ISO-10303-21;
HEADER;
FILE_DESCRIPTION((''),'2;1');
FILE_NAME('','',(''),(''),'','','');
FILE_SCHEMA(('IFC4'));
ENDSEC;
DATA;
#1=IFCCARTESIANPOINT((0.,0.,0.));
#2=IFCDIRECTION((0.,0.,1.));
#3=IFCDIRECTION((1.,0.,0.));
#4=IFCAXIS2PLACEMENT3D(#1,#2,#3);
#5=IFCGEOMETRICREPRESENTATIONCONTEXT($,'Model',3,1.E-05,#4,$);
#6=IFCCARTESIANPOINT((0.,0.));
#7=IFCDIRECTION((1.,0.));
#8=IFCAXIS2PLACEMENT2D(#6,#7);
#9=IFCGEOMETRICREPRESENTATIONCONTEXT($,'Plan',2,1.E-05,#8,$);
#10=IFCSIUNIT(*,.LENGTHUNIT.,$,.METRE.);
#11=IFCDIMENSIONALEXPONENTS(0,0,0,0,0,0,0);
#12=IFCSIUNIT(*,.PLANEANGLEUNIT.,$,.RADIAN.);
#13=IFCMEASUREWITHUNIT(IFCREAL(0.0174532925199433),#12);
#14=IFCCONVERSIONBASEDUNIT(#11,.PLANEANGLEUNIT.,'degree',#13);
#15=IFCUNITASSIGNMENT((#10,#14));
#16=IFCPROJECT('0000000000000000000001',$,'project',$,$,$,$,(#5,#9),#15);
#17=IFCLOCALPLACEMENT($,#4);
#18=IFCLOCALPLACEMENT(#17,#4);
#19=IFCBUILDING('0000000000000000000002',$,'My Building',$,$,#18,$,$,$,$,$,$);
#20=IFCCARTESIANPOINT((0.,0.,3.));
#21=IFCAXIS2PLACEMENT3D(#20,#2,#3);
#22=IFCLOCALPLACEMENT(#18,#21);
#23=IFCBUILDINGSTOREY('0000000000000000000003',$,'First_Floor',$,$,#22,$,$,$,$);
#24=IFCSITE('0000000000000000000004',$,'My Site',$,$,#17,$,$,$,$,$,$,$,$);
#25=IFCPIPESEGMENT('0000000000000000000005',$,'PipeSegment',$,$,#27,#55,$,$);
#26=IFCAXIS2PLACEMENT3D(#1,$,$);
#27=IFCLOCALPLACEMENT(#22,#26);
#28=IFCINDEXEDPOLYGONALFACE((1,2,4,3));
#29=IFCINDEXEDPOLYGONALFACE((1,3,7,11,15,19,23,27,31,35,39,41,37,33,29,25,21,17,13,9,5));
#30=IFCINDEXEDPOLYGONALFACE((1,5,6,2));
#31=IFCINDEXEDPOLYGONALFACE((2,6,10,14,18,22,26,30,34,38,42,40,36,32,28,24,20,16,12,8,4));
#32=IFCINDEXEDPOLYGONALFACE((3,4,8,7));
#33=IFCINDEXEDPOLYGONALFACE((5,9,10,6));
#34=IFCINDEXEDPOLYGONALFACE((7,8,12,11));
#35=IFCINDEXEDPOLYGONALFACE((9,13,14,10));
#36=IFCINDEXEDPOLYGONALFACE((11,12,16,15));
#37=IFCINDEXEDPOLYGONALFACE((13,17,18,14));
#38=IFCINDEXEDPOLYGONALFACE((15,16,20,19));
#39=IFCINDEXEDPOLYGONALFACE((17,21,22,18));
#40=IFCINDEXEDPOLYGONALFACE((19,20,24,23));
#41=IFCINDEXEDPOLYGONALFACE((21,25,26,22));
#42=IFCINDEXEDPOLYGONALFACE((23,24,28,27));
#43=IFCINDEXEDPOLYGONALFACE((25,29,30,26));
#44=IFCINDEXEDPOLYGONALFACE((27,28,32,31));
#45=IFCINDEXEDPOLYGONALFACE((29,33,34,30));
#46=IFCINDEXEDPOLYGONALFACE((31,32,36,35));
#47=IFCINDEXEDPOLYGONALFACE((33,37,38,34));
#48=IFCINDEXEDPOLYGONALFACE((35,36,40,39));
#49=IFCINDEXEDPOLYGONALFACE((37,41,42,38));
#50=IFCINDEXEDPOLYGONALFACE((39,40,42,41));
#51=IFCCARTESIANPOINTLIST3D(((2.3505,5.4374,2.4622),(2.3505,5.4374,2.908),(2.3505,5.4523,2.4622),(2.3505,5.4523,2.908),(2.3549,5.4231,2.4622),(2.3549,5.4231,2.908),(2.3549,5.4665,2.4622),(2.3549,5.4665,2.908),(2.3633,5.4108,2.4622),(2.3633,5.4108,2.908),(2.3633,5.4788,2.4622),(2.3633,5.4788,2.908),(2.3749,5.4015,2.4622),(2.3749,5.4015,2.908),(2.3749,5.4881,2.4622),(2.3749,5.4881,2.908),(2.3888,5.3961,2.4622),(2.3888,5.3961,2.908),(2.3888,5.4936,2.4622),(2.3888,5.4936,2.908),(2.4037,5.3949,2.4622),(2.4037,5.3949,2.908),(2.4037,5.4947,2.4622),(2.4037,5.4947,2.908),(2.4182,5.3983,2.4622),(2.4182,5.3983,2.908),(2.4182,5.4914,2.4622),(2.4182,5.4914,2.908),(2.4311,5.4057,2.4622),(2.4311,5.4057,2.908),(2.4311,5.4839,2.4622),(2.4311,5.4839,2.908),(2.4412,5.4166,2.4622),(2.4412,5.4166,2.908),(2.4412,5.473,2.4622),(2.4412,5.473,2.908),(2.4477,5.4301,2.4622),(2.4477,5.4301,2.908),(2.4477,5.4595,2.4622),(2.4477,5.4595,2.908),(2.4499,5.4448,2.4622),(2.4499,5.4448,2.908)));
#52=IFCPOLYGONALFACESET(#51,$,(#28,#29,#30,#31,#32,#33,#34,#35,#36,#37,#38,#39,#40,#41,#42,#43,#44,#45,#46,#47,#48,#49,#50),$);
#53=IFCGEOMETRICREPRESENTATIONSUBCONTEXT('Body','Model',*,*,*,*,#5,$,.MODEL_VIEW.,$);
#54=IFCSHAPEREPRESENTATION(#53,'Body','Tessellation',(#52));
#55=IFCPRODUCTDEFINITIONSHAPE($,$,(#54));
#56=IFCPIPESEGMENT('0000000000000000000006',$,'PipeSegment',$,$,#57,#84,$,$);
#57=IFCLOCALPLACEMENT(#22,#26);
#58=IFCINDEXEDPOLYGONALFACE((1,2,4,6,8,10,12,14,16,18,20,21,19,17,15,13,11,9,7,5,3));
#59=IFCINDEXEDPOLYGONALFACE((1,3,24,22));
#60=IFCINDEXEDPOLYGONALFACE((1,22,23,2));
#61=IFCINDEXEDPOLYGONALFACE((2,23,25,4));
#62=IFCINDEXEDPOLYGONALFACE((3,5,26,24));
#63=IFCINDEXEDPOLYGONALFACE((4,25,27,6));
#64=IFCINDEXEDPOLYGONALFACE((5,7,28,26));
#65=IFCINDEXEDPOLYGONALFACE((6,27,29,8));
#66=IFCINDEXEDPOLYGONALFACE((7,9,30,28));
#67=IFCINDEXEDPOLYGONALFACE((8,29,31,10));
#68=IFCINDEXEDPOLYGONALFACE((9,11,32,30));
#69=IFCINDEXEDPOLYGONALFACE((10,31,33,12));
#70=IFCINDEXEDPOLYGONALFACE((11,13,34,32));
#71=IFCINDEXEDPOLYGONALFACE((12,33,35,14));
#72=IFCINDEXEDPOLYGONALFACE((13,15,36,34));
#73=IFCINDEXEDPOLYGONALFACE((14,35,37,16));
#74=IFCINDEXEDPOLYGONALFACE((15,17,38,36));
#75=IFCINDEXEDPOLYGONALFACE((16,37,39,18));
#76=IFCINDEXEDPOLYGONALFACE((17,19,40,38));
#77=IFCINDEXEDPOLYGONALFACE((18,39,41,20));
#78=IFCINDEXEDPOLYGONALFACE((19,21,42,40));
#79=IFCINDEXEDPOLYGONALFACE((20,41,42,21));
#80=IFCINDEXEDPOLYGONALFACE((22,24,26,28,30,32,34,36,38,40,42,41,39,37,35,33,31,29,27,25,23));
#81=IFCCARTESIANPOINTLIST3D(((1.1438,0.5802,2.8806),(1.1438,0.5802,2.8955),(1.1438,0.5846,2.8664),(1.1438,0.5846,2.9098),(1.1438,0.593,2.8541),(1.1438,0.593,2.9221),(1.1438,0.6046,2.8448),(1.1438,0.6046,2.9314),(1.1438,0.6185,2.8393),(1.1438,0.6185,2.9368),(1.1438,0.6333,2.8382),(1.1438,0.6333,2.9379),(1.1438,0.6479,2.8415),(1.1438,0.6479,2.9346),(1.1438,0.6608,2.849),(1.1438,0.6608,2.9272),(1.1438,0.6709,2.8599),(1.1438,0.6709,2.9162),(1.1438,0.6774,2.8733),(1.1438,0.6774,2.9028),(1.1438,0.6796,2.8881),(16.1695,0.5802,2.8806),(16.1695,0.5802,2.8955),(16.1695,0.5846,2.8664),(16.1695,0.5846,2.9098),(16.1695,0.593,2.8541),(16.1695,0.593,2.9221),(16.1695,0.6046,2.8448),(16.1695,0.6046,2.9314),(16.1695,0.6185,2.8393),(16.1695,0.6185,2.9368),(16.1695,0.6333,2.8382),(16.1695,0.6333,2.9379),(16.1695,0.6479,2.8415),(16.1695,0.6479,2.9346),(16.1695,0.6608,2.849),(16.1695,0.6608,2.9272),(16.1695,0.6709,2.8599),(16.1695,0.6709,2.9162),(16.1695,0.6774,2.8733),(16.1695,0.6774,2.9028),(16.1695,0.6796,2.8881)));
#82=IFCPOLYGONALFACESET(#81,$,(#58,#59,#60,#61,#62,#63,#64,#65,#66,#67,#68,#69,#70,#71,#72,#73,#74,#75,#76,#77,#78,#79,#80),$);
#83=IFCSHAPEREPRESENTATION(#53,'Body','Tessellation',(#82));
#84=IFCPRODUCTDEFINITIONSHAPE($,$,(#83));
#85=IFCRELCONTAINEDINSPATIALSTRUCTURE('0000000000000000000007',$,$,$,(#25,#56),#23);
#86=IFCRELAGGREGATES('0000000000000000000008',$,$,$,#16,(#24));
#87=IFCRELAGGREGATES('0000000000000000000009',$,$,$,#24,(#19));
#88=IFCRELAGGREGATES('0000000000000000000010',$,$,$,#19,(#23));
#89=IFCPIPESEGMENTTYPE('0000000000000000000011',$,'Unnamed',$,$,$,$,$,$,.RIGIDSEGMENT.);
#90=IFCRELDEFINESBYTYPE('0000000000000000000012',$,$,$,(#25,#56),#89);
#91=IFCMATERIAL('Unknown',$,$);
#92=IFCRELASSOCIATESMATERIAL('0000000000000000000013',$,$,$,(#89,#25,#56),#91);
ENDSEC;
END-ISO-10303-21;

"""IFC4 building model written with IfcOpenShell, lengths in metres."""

from ifc_helpers import new_model, entity, si_unit, converted_unit, frame, origin_with_axes, origin_2d_with_axis, place, context, subcontext, project, spatial, circle, extrude, material, material_profile, profile_set, profile_usage, type_object, element, save


model = new_model("IFC4")

# Units and contexts
model_context = context("Model", 3, precision=1e-05, world=origin_with_axes())
plan_context = context("Plan", 2, precision=1e-05, world=origin_2d_with_axis())
body_context = subcontext(model_context, "Body", "Model", "MODEL_VIEW")
ifc_project = project(units=[si_unit("LENGTHUNIT", "METRE"), converted_unit("PLANEANGLEUNIT", "degree", entity("IfcReal", 0.0174532925199433), si_unit("PLANEANGLEUNIT", "RADIAN"), dimensions=[0, 0, 0, 0, 0, 0, 0])], contexts=[model_context, plan_context])

# Site, building, storey
site_placement = place(None, origin_with_axes())
site = spatial("IfcSite", under=ifc_project, at=site_placement, Name="My Site")
building_placement = place(site_placement, origin_with_axes())
building = spatial("IfcBuilding", under=site, at=building_placement, Name="My Building")
storey_placement = place(building_placement, frame((0.0, 0.0, 3.0), z_axis=(0.0, 0.0, 1.0), x_axis=(1.0, 0.0, 0.0)))
storey = spatial("IfcBuildingStorey", under=building, at=storey_placement, Name="First_Floor")

# Shared definitions
ifc_material = material(Name="Unknown")

# Pipe segments
ifc_material_profile_1 = material_profile(ifc_material, circle(Radius=0.05))
ifc_profile_set_1 = profile_set([ifc_material_profile_1])
pipe_segment_type = type_object("IfcPipeSegmentType", Name="Unnamed", PredefinedType="RIGIDSEGMENT", material=ifc_profile_set_1)
ifc_profile_usage_1 = profile_usage(ifc_profile_set_1, cardinal=5)
pipe_segment_1_placement = place(storey_placement, frame((2.3999, 5.4448, 2.908), z_axis=(0.0, 0.0, -1.0), x_axis=(1.0, 0.0, 0.0)))
element("IfcPipeSegment", 1, at=pipe_segment_1_placement, inside=storey, type_object=pipe_segment_type, material=ifc_profile_usage_1, Name="PipeSegment", context=body_context, shape_type="SweptSolid", body=[
    extrude(circle(Radius=0.05), origin_with_axes(), (0.0, 0.0, 1.0), 0.4458),
])
ifc_profile_usage_2 = profile_usage(ifc_profile_set_1, cardinal=5)
pipe_segment_2_placement = place(storey_placement, frame((1.1438, 0.6296, 2.8881), z_axis=(1.0, 0.0, 0.0), x_axis=(0.0, 1.0, 0.0)))
element("IfcPipeSegment", 2, at=pipe_segment_2_placement, inside=storey, type_object=pipe_segment_type, material=ifc_profile_usage_2, Name="PipeSegment", context=body_context, shape_type="SweptSolid", body=[
    extrude(circle(Radius=0.05), origin_with_axes(), (0.0, 0.0, 1.0), 15.0257),
])

save(model, "model.ifc")
